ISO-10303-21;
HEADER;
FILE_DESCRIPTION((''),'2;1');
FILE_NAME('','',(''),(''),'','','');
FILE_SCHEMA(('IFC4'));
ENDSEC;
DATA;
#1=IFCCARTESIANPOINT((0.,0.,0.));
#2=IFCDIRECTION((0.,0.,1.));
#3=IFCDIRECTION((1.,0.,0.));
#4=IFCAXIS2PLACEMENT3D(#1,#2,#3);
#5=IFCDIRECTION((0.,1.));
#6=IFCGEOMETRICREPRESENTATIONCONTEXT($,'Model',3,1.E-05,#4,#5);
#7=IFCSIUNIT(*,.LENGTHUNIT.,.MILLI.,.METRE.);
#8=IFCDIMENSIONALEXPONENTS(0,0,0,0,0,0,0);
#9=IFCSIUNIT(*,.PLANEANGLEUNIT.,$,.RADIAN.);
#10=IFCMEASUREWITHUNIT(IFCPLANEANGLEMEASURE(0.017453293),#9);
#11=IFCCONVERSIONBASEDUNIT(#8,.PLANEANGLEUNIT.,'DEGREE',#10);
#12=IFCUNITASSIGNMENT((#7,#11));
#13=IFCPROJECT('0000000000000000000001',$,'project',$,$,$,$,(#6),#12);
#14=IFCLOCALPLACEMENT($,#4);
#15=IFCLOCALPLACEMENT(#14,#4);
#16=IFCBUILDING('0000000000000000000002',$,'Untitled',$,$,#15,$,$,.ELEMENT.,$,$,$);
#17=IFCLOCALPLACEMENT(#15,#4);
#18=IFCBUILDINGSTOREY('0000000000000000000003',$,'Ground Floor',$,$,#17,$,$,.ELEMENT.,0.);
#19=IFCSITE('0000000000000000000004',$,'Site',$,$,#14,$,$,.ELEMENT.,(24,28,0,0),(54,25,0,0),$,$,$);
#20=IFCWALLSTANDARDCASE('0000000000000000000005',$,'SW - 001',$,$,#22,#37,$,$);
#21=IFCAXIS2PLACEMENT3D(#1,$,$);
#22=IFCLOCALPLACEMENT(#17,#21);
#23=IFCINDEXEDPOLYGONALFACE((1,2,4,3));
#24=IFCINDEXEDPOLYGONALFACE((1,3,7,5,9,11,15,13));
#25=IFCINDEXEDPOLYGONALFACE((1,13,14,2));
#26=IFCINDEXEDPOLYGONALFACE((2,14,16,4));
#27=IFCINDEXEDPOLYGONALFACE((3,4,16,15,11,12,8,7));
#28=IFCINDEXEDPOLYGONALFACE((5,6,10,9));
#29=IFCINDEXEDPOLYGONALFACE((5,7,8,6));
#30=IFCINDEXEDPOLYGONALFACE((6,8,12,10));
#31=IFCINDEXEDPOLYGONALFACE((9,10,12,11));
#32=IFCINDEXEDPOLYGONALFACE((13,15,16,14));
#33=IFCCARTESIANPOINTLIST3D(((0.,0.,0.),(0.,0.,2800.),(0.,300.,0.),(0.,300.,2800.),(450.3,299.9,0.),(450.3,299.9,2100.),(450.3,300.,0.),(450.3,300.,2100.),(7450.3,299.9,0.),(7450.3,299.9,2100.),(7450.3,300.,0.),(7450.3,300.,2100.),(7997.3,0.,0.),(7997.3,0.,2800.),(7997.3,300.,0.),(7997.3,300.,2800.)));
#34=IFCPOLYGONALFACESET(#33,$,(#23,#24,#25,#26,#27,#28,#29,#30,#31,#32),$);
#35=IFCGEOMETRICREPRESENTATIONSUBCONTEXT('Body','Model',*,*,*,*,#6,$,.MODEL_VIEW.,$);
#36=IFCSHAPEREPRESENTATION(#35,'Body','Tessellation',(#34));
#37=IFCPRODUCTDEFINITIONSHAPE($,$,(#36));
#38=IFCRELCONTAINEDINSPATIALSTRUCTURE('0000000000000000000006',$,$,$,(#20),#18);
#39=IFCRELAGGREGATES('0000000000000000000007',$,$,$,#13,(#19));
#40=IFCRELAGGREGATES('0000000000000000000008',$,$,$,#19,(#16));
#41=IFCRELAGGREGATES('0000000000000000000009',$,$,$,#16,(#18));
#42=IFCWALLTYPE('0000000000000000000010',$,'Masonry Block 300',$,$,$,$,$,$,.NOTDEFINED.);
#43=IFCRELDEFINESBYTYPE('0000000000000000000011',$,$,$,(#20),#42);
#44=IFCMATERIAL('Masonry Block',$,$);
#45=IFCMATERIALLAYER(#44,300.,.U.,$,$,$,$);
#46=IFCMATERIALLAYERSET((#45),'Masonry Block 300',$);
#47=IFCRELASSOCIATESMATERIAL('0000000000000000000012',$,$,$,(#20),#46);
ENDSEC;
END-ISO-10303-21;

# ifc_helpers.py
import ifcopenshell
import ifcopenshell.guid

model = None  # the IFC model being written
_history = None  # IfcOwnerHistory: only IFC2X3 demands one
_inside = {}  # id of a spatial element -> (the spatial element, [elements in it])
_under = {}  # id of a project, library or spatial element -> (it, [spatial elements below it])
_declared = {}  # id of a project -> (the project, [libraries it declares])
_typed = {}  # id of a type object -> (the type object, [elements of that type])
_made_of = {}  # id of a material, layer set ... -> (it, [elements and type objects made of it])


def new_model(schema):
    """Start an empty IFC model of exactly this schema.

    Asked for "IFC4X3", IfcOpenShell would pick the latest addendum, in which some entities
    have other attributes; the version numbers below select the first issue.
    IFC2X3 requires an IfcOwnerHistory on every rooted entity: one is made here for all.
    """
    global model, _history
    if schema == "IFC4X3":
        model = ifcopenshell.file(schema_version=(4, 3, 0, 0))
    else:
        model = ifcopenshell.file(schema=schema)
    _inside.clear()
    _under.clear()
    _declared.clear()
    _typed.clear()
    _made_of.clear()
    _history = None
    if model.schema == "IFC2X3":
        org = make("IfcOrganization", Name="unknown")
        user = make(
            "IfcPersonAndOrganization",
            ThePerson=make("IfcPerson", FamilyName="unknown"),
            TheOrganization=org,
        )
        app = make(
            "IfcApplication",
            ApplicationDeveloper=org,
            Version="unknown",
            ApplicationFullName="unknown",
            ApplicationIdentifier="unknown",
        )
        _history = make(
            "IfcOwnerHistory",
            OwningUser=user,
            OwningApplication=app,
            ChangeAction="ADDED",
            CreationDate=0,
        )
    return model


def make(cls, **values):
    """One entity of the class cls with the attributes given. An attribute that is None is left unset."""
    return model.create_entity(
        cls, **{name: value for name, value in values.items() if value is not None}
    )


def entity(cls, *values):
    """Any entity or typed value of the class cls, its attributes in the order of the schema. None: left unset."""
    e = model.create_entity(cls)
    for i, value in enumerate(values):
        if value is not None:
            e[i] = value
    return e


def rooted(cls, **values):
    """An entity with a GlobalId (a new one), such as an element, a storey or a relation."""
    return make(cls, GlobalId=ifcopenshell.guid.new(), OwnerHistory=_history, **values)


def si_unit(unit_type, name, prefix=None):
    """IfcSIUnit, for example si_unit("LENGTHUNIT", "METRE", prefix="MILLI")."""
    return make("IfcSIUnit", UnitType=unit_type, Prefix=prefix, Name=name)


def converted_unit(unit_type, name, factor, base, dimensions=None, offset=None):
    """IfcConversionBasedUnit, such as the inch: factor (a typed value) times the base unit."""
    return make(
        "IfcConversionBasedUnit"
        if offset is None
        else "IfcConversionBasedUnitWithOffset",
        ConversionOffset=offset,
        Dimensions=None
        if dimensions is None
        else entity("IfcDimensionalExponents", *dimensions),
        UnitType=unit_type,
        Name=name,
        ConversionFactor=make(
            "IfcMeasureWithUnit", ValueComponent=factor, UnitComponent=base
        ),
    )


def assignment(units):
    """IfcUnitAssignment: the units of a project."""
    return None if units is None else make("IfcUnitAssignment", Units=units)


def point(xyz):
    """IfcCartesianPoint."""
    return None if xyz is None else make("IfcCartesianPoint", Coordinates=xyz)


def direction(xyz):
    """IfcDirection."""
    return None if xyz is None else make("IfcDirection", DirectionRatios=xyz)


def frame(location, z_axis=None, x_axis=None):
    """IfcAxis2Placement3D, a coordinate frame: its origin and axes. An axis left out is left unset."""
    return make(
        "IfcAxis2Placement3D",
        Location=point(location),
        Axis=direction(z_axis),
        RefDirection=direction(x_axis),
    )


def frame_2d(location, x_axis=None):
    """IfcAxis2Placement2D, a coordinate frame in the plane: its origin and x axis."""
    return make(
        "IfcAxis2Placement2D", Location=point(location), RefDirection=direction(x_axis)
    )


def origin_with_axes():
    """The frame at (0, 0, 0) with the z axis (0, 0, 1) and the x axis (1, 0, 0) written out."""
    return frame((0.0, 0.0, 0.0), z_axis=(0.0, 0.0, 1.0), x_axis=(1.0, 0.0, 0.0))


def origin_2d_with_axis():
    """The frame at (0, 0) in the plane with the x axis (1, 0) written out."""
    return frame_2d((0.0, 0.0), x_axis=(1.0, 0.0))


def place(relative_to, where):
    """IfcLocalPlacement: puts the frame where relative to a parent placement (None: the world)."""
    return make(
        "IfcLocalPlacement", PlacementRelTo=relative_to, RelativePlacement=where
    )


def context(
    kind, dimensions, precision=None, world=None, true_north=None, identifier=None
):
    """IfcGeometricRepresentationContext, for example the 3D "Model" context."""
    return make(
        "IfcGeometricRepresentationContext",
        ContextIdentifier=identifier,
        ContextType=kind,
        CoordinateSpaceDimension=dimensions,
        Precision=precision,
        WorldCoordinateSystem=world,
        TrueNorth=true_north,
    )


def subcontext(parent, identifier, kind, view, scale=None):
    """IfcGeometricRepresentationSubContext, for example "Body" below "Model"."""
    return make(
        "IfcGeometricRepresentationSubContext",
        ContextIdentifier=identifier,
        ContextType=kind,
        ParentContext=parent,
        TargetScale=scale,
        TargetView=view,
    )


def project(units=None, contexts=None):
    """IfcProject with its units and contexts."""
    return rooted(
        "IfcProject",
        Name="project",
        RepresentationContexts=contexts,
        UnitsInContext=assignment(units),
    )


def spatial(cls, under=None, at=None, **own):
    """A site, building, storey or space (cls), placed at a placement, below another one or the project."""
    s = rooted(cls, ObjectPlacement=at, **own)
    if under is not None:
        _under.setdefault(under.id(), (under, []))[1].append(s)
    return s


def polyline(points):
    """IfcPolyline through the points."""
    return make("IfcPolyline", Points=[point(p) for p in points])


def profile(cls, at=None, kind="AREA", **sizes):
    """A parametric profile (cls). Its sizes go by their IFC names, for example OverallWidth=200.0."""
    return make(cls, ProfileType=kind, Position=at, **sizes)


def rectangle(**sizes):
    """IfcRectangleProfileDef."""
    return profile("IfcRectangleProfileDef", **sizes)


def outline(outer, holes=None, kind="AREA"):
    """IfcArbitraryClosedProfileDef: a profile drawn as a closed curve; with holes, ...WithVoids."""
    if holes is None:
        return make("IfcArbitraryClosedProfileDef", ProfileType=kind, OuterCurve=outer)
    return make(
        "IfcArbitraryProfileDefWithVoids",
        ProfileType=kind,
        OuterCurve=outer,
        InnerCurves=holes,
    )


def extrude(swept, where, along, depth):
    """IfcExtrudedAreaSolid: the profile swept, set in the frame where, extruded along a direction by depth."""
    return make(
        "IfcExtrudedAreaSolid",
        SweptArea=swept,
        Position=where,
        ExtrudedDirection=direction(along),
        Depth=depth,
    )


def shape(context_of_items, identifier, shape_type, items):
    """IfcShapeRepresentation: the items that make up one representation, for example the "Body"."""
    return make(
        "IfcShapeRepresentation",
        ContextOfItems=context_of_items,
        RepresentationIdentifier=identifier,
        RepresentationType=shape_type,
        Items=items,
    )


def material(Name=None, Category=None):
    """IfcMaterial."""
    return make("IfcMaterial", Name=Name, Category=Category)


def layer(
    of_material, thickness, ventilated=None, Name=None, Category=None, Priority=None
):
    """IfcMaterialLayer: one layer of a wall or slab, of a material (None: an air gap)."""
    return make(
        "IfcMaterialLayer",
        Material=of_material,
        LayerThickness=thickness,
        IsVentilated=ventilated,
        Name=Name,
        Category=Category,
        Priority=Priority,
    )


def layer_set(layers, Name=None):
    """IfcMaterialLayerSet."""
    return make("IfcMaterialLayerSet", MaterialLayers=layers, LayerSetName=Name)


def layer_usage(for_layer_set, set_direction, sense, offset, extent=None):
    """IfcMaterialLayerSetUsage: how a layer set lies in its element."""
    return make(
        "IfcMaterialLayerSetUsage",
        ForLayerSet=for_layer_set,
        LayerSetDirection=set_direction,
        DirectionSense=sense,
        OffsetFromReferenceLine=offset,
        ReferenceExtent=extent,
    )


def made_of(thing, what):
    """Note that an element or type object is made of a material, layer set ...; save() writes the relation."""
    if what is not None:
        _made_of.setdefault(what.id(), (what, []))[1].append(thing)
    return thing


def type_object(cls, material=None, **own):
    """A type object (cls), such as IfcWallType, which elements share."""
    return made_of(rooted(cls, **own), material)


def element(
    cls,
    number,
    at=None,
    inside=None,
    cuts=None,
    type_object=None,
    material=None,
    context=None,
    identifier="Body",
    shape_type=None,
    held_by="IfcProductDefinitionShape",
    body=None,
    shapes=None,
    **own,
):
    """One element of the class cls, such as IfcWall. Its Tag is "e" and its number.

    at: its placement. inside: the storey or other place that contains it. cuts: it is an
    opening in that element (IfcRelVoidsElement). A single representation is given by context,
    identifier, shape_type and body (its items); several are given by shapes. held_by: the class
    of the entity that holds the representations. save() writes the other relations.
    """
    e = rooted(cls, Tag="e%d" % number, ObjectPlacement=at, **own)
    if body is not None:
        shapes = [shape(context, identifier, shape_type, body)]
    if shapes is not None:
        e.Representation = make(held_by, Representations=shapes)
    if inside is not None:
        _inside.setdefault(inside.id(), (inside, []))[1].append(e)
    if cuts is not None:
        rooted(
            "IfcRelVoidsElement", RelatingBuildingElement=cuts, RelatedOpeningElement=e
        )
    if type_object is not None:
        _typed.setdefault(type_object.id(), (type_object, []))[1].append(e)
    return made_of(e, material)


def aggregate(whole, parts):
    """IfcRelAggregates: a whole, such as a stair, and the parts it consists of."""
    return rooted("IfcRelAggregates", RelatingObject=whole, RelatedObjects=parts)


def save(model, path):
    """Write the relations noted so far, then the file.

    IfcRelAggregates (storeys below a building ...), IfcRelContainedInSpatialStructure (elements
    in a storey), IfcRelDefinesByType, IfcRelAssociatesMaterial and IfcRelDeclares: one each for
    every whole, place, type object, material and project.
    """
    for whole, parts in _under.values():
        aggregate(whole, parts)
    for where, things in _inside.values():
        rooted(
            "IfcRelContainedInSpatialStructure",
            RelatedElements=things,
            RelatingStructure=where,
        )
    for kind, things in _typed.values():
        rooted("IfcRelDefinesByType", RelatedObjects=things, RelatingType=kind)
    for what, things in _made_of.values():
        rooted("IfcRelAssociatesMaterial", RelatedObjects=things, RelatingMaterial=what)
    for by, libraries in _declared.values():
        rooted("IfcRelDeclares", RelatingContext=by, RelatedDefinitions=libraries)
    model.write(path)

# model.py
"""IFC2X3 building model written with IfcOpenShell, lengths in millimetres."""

from ifc_helpers import new_model, entity, si_unit, converted_unit, direction, frame, origin_with_axes, origin_2d_with_axis, place, context, subcontext, project, spatial, polyline, rectangle, outline, extrude, material, layer, layer_set, layer_usage, type_object, element, save


model = new_model("IFC2X3")

# Units and contexts
model_context = context("Model", 3, precision=1e-05, world=origin_with_axes(), true_north=direction((0.0, 1.0)))
body_context = subcontext(model_context, "Body", "Model", "MODEL_VIEW")
ifc_project = project(units=[si_unit("LENGTHUNIT", "METRE", prefix="MILLI"), converted_unit("PLANEANGLEUNIT", "DEGREE", entity("IfcPlaneAngleMeasure", 0.017453293), si_unit("PLANEANGLEUNIT", "RADIAN"), dimensions=[0, 0, 0, 0, 0, 0, 0])], contexts=[model_context])

# Site, building, storey
site_placement = place(None, origin_with_axes())
site = spatial("IfcSite", under=ifc_project, at=site_placement, Name="Site", CompositionType="ELEMENT", RefLatitude=(24, 28, 0, 0), RefLongitude=(54, 25, 0, 0))
building_placement = place(site_placement, origin_with_axes())
building = spatial("IfcBuilding", under=site, at=building_placement, Name="Untitled", CompositionType="ELEMENT")
storey_placement = place(building_placement, origin_with_axes())
storey = spatial("IfcBuildingStorey", under=building, at=storey_placement, Name="Ground Floor", CompositionType="ELEMENT", Elevation=0.0)

# Wall, opening
ifc_material = material(Name="Masonry Block")
ifc_layer = layer(ifc_material, 300.0, ventilated="UNKNOWN")
ifc_layer_set = layer_set([ifc_layer], Name="Masonry Block 300")
ifc_layer_usage = layer_usage(ifc_layer_set, "AXIS2", "POSITIVE", 0.0)
wall_type = type_object("IfcWallType", Name="Masonry Block 300", PredefinedType="NOTDEFINED")
wall_placement = place(storey_placement, origin_with_axes())
wall = element("IfcWallStandardCase", 1, at=wall_placement, inside=storey, type_object=wall_type, material=ifc_layer_usage, Name="SW - 001", context=body_context, shape_type="SweptSolid", body=[
    extrude(outline(polyline([(0.0, 0.0), (7997.3, 0.0), (7997.3, 300.0), (0.0, 300.0), (0.0, 0.0)])), origin_with_axes(), (0.0, 0.0, 1.0), 2800.0),
])
opening_placement = place(wall_placement, frame((3950.3, 0.0, 0.0), z_axis=(0.0, 0.0, 1.0), x_axis=(1.0, 0.0, 0.0)))
element("IfcOpeningElement", 2, at=opening_placement, cuts=wall, context=body_context, shape_type="SweptSolid", body=[
    extrude(rectangle(XDim=7000.0, YDim=2100.0, at=origin_2d_with_axis()), frame((0.0, 300.1, 1050.0), z_axis=(0.0, -1.0, 0.0), x_axis=(1.0, 0.0, 0.0)), (0.0, 0.0, 1.0), 0.2),
    extrude(rectangle(XDim=7000.0, YDim=2100.0, at=origin_2d_with_axis()), frame((0.0, 299.9, 1050.0), z_axis=(0.0, 1.0, 0.0), x_axis=(-1.0, 0.0, 0.0)), (0.0, 0.0, 1.0), 0.2),
])

save(model, "model.ifc")
